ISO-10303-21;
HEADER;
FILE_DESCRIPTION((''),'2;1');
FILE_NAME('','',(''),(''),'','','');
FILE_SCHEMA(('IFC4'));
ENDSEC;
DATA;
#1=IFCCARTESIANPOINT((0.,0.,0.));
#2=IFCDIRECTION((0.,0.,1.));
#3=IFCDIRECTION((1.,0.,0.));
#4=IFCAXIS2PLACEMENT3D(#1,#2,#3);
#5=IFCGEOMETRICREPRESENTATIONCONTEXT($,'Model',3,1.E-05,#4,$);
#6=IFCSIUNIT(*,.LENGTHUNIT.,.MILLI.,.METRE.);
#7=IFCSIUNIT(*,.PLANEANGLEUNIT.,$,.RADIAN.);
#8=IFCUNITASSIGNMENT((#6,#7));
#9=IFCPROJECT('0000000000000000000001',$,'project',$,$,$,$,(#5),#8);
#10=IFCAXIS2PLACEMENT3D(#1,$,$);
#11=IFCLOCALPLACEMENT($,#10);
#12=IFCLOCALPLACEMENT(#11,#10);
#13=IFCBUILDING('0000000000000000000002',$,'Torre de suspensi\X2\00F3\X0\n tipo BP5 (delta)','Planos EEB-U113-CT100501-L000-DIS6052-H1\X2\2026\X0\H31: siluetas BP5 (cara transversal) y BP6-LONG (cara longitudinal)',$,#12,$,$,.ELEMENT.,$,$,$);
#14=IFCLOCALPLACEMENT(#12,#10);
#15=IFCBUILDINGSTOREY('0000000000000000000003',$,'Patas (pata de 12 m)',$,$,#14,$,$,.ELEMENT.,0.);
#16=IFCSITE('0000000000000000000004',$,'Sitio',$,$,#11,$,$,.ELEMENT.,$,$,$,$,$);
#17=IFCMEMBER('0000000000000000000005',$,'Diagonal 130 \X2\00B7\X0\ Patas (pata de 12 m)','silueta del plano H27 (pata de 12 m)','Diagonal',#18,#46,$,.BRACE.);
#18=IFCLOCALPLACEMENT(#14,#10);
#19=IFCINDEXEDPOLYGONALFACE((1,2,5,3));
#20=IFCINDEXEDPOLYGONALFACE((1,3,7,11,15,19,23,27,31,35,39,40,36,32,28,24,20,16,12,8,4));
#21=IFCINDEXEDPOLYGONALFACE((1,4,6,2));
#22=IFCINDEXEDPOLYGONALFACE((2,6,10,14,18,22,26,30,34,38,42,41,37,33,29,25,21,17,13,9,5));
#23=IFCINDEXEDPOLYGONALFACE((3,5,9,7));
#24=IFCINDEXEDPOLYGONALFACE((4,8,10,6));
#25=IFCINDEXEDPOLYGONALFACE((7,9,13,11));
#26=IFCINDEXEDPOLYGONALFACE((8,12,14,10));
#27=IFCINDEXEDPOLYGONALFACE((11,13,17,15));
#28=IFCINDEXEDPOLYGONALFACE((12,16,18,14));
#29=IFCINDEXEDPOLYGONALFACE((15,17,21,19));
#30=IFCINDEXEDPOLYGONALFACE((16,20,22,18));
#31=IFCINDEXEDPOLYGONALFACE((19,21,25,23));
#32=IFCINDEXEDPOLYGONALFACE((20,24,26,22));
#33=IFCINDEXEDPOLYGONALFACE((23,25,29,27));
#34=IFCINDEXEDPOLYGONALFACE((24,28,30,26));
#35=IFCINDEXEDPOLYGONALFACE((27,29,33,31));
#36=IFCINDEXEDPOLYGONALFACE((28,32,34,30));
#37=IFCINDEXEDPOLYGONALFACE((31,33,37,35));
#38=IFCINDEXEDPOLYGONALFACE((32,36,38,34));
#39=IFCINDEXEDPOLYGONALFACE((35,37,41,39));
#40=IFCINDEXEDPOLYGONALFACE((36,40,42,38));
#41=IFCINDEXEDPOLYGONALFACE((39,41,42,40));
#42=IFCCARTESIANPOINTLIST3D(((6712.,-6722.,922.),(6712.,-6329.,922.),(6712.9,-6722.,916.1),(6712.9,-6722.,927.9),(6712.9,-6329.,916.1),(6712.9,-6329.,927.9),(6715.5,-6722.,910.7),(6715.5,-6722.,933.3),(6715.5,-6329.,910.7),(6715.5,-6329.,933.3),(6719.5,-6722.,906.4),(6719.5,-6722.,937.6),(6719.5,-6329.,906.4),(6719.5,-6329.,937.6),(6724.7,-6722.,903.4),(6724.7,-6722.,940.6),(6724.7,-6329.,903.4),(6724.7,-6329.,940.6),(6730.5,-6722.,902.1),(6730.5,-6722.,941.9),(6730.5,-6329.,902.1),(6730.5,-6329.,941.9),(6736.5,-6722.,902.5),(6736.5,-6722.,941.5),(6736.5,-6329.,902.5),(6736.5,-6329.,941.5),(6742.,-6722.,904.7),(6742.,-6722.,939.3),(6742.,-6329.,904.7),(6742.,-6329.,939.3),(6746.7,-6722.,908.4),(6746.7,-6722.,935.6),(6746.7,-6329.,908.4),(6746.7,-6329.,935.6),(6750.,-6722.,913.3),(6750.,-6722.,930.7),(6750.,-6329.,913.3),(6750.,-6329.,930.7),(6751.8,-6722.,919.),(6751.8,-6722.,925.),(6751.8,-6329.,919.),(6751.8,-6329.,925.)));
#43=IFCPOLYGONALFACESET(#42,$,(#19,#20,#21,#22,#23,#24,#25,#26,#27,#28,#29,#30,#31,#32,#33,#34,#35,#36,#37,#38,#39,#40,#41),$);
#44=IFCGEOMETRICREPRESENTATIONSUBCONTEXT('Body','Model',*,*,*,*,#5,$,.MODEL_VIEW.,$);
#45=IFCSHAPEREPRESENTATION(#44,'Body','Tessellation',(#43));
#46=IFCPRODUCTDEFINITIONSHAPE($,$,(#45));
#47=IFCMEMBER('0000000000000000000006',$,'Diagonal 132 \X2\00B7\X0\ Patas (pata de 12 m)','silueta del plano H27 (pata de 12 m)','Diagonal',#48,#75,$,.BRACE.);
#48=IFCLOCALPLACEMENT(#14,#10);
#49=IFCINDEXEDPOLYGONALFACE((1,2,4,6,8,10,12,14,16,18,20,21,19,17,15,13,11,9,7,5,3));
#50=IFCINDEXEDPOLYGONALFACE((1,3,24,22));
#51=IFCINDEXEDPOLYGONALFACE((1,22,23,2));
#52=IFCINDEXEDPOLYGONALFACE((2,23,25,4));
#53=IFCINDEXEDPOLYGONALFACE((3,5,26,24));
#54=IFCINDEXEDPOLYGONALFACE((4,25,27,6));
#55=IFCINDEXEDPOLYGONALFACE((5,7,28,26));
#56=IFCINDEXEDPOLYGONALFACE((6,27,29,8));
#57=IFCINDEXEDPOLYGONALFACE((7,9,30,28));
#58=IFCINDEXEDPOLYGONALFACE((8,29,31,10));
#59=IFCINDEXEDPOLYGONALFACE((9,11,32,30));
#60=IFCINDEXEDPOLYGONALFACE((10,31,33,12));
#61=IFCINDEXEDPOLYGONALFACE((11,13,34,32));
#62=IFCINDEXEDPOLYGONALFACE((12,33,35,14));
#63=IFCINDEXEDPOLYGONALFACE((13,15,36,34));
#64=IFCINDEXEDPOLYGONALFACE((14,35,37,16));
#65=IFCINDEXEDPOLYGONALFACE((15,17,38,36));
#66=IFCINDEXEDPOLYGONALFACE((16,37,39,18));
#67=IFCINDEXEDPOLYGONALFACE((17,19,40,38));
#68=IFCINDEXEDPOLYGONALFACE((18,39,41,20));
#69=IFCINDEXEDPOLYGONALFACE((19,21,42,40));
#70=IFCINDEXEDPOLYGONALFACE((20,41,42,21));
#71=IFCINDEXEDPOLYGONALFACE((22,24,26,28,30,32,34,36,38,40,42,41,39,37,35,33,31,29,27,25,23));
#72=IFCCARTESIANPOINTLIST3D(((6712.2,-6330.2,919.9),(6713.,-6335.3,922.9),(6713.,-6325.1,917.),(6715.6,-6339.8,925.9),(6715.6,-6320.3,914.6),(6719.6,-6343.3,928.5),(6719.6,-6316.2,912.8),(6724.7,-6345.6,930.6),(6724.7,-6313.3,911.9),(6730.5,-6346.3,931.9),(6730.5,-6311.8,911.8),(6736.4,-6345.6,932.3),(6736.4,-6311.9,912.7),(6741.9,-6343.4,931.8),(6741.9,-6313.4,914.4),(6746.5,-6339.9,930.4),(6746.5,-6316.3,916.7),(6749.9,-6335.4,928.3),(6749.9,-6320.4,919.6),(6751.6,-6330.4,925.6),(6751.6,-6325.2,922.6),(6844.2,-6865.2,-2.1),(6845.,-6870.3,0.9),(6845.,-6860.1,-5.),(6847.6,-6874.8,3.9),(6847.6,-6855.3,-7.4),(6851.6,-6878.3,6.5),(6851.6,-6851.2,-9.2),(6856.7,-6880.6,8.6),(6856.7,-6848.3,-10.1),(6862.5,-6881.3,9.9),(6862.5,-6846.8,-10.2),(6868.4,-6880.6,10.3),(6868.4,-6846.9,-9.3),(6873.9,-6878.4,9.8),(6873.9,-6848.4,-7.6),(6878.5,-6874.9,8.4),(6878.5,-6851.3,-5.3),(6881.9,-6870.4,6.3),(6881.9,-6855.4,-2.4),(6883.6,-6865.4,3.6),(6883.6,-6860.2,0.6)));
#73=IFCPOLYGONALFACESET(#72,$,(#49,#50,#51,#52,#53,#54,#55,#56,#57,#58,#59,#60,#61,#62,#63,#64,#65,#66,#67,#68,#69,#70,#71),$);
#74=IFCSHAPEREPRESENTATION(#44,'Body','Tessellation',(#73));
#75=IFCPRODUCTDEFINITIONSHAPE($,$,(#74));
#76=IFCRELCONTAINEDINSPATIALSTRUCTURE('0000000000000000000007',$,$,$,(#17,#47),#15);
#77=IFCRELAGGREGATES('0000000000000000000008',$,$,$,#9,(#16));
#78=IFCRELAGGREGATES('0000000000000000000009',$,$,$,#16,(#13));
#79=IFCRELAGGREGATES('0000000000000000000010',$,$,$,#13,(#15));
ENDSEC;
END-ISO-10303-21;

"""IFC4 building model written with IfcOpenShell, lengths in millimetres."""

from ifc_helpers import new_model, si_unit, frame, origin, origin_with_axes, place, context, subcontext, project, spatial, circle, extrude, element, save


model = new_model("IFC4")

# Units and contexts
model_context = context("Model", 3, precision=1e-05, world=origin_with_axes())
body_context = subcontext(model_context, "Body", "Model", "MODEL_VIEW")
ifc_project = project(units=[si_unit("LENGTHUNIT", "METRE", prefix="MILLI"), si_unit("PLANEANGLEUNIT", "RADIAN")], contexts=[model_context])

# Site, building, storey
site_placement = place(None, origin())
site = spatial("IfcSite", under=ifc_project, at=site_placement, Name="Sitio", CompositionType="ELEMENT")
building_placement = place(site_placement, origin())
building = spatial("IfcBuilding", under=site, at=building_placement, Name="Torre de suspensión tipo BP5 (delta)", Description="Planos EEB-U113-CT100501-L000-DIS6052-H1…H31: siluetas BP5 (cara transversal) y BP6-LONG (cara longitudinal)", CompositionType="ELEMENT")
storey_placement = place(building_placement, origin())
storey = spatial("IfcBuildingStorey", under=building, at=storey_placement, Name="Patas (pata de 12 m)", CompositionType="ELEMENT", Elevation=0.0)

# Members
member_1_placement = place(storey_placement, frame((6732.0, -6722.0, 922.0), z_axis=(0.0, 1.0, 0.0), x_axis=(-1.0, 0.0, 0.0)))
element("IfcMember", 1, at=member_1_placement, inside=storey, Name="Diagonal 130 · Patas (pata de 12 m)", Description="silueta del plano H27 (pata de 12 m)", ObjectType="Diagonal", PredefinedType="BRACE", context=body_context, shape_type="SweptSolid", body=[
    extrude(circle(Radius=20.0), None, (0.0, 0.0, 1.0), 393.0),
])
member_2_placement = place(storey_placement, frame((6864.0, -6864.0, 0.0), z_axis=(-0.122891, 0.498082, 0.858377), x_axis=(-0.99242, -0.061678, -0.106293)))
element("IfcMember", 2, at=member_2_placement, inside=storey, Name="Diagonal 132 · Patas (pata de 12 m)", Description="silueta del plano H27 (pata de 12 m)", ObjectType="Diagonal", PredefinedType="BRACE", context=body_context, shape_type="SweptSolid", body=[
    extrude(circle(Radius=20.0), None, (0.0, 0.0, 1.0), 1074.1),
])

save(model, "model.ifc")
